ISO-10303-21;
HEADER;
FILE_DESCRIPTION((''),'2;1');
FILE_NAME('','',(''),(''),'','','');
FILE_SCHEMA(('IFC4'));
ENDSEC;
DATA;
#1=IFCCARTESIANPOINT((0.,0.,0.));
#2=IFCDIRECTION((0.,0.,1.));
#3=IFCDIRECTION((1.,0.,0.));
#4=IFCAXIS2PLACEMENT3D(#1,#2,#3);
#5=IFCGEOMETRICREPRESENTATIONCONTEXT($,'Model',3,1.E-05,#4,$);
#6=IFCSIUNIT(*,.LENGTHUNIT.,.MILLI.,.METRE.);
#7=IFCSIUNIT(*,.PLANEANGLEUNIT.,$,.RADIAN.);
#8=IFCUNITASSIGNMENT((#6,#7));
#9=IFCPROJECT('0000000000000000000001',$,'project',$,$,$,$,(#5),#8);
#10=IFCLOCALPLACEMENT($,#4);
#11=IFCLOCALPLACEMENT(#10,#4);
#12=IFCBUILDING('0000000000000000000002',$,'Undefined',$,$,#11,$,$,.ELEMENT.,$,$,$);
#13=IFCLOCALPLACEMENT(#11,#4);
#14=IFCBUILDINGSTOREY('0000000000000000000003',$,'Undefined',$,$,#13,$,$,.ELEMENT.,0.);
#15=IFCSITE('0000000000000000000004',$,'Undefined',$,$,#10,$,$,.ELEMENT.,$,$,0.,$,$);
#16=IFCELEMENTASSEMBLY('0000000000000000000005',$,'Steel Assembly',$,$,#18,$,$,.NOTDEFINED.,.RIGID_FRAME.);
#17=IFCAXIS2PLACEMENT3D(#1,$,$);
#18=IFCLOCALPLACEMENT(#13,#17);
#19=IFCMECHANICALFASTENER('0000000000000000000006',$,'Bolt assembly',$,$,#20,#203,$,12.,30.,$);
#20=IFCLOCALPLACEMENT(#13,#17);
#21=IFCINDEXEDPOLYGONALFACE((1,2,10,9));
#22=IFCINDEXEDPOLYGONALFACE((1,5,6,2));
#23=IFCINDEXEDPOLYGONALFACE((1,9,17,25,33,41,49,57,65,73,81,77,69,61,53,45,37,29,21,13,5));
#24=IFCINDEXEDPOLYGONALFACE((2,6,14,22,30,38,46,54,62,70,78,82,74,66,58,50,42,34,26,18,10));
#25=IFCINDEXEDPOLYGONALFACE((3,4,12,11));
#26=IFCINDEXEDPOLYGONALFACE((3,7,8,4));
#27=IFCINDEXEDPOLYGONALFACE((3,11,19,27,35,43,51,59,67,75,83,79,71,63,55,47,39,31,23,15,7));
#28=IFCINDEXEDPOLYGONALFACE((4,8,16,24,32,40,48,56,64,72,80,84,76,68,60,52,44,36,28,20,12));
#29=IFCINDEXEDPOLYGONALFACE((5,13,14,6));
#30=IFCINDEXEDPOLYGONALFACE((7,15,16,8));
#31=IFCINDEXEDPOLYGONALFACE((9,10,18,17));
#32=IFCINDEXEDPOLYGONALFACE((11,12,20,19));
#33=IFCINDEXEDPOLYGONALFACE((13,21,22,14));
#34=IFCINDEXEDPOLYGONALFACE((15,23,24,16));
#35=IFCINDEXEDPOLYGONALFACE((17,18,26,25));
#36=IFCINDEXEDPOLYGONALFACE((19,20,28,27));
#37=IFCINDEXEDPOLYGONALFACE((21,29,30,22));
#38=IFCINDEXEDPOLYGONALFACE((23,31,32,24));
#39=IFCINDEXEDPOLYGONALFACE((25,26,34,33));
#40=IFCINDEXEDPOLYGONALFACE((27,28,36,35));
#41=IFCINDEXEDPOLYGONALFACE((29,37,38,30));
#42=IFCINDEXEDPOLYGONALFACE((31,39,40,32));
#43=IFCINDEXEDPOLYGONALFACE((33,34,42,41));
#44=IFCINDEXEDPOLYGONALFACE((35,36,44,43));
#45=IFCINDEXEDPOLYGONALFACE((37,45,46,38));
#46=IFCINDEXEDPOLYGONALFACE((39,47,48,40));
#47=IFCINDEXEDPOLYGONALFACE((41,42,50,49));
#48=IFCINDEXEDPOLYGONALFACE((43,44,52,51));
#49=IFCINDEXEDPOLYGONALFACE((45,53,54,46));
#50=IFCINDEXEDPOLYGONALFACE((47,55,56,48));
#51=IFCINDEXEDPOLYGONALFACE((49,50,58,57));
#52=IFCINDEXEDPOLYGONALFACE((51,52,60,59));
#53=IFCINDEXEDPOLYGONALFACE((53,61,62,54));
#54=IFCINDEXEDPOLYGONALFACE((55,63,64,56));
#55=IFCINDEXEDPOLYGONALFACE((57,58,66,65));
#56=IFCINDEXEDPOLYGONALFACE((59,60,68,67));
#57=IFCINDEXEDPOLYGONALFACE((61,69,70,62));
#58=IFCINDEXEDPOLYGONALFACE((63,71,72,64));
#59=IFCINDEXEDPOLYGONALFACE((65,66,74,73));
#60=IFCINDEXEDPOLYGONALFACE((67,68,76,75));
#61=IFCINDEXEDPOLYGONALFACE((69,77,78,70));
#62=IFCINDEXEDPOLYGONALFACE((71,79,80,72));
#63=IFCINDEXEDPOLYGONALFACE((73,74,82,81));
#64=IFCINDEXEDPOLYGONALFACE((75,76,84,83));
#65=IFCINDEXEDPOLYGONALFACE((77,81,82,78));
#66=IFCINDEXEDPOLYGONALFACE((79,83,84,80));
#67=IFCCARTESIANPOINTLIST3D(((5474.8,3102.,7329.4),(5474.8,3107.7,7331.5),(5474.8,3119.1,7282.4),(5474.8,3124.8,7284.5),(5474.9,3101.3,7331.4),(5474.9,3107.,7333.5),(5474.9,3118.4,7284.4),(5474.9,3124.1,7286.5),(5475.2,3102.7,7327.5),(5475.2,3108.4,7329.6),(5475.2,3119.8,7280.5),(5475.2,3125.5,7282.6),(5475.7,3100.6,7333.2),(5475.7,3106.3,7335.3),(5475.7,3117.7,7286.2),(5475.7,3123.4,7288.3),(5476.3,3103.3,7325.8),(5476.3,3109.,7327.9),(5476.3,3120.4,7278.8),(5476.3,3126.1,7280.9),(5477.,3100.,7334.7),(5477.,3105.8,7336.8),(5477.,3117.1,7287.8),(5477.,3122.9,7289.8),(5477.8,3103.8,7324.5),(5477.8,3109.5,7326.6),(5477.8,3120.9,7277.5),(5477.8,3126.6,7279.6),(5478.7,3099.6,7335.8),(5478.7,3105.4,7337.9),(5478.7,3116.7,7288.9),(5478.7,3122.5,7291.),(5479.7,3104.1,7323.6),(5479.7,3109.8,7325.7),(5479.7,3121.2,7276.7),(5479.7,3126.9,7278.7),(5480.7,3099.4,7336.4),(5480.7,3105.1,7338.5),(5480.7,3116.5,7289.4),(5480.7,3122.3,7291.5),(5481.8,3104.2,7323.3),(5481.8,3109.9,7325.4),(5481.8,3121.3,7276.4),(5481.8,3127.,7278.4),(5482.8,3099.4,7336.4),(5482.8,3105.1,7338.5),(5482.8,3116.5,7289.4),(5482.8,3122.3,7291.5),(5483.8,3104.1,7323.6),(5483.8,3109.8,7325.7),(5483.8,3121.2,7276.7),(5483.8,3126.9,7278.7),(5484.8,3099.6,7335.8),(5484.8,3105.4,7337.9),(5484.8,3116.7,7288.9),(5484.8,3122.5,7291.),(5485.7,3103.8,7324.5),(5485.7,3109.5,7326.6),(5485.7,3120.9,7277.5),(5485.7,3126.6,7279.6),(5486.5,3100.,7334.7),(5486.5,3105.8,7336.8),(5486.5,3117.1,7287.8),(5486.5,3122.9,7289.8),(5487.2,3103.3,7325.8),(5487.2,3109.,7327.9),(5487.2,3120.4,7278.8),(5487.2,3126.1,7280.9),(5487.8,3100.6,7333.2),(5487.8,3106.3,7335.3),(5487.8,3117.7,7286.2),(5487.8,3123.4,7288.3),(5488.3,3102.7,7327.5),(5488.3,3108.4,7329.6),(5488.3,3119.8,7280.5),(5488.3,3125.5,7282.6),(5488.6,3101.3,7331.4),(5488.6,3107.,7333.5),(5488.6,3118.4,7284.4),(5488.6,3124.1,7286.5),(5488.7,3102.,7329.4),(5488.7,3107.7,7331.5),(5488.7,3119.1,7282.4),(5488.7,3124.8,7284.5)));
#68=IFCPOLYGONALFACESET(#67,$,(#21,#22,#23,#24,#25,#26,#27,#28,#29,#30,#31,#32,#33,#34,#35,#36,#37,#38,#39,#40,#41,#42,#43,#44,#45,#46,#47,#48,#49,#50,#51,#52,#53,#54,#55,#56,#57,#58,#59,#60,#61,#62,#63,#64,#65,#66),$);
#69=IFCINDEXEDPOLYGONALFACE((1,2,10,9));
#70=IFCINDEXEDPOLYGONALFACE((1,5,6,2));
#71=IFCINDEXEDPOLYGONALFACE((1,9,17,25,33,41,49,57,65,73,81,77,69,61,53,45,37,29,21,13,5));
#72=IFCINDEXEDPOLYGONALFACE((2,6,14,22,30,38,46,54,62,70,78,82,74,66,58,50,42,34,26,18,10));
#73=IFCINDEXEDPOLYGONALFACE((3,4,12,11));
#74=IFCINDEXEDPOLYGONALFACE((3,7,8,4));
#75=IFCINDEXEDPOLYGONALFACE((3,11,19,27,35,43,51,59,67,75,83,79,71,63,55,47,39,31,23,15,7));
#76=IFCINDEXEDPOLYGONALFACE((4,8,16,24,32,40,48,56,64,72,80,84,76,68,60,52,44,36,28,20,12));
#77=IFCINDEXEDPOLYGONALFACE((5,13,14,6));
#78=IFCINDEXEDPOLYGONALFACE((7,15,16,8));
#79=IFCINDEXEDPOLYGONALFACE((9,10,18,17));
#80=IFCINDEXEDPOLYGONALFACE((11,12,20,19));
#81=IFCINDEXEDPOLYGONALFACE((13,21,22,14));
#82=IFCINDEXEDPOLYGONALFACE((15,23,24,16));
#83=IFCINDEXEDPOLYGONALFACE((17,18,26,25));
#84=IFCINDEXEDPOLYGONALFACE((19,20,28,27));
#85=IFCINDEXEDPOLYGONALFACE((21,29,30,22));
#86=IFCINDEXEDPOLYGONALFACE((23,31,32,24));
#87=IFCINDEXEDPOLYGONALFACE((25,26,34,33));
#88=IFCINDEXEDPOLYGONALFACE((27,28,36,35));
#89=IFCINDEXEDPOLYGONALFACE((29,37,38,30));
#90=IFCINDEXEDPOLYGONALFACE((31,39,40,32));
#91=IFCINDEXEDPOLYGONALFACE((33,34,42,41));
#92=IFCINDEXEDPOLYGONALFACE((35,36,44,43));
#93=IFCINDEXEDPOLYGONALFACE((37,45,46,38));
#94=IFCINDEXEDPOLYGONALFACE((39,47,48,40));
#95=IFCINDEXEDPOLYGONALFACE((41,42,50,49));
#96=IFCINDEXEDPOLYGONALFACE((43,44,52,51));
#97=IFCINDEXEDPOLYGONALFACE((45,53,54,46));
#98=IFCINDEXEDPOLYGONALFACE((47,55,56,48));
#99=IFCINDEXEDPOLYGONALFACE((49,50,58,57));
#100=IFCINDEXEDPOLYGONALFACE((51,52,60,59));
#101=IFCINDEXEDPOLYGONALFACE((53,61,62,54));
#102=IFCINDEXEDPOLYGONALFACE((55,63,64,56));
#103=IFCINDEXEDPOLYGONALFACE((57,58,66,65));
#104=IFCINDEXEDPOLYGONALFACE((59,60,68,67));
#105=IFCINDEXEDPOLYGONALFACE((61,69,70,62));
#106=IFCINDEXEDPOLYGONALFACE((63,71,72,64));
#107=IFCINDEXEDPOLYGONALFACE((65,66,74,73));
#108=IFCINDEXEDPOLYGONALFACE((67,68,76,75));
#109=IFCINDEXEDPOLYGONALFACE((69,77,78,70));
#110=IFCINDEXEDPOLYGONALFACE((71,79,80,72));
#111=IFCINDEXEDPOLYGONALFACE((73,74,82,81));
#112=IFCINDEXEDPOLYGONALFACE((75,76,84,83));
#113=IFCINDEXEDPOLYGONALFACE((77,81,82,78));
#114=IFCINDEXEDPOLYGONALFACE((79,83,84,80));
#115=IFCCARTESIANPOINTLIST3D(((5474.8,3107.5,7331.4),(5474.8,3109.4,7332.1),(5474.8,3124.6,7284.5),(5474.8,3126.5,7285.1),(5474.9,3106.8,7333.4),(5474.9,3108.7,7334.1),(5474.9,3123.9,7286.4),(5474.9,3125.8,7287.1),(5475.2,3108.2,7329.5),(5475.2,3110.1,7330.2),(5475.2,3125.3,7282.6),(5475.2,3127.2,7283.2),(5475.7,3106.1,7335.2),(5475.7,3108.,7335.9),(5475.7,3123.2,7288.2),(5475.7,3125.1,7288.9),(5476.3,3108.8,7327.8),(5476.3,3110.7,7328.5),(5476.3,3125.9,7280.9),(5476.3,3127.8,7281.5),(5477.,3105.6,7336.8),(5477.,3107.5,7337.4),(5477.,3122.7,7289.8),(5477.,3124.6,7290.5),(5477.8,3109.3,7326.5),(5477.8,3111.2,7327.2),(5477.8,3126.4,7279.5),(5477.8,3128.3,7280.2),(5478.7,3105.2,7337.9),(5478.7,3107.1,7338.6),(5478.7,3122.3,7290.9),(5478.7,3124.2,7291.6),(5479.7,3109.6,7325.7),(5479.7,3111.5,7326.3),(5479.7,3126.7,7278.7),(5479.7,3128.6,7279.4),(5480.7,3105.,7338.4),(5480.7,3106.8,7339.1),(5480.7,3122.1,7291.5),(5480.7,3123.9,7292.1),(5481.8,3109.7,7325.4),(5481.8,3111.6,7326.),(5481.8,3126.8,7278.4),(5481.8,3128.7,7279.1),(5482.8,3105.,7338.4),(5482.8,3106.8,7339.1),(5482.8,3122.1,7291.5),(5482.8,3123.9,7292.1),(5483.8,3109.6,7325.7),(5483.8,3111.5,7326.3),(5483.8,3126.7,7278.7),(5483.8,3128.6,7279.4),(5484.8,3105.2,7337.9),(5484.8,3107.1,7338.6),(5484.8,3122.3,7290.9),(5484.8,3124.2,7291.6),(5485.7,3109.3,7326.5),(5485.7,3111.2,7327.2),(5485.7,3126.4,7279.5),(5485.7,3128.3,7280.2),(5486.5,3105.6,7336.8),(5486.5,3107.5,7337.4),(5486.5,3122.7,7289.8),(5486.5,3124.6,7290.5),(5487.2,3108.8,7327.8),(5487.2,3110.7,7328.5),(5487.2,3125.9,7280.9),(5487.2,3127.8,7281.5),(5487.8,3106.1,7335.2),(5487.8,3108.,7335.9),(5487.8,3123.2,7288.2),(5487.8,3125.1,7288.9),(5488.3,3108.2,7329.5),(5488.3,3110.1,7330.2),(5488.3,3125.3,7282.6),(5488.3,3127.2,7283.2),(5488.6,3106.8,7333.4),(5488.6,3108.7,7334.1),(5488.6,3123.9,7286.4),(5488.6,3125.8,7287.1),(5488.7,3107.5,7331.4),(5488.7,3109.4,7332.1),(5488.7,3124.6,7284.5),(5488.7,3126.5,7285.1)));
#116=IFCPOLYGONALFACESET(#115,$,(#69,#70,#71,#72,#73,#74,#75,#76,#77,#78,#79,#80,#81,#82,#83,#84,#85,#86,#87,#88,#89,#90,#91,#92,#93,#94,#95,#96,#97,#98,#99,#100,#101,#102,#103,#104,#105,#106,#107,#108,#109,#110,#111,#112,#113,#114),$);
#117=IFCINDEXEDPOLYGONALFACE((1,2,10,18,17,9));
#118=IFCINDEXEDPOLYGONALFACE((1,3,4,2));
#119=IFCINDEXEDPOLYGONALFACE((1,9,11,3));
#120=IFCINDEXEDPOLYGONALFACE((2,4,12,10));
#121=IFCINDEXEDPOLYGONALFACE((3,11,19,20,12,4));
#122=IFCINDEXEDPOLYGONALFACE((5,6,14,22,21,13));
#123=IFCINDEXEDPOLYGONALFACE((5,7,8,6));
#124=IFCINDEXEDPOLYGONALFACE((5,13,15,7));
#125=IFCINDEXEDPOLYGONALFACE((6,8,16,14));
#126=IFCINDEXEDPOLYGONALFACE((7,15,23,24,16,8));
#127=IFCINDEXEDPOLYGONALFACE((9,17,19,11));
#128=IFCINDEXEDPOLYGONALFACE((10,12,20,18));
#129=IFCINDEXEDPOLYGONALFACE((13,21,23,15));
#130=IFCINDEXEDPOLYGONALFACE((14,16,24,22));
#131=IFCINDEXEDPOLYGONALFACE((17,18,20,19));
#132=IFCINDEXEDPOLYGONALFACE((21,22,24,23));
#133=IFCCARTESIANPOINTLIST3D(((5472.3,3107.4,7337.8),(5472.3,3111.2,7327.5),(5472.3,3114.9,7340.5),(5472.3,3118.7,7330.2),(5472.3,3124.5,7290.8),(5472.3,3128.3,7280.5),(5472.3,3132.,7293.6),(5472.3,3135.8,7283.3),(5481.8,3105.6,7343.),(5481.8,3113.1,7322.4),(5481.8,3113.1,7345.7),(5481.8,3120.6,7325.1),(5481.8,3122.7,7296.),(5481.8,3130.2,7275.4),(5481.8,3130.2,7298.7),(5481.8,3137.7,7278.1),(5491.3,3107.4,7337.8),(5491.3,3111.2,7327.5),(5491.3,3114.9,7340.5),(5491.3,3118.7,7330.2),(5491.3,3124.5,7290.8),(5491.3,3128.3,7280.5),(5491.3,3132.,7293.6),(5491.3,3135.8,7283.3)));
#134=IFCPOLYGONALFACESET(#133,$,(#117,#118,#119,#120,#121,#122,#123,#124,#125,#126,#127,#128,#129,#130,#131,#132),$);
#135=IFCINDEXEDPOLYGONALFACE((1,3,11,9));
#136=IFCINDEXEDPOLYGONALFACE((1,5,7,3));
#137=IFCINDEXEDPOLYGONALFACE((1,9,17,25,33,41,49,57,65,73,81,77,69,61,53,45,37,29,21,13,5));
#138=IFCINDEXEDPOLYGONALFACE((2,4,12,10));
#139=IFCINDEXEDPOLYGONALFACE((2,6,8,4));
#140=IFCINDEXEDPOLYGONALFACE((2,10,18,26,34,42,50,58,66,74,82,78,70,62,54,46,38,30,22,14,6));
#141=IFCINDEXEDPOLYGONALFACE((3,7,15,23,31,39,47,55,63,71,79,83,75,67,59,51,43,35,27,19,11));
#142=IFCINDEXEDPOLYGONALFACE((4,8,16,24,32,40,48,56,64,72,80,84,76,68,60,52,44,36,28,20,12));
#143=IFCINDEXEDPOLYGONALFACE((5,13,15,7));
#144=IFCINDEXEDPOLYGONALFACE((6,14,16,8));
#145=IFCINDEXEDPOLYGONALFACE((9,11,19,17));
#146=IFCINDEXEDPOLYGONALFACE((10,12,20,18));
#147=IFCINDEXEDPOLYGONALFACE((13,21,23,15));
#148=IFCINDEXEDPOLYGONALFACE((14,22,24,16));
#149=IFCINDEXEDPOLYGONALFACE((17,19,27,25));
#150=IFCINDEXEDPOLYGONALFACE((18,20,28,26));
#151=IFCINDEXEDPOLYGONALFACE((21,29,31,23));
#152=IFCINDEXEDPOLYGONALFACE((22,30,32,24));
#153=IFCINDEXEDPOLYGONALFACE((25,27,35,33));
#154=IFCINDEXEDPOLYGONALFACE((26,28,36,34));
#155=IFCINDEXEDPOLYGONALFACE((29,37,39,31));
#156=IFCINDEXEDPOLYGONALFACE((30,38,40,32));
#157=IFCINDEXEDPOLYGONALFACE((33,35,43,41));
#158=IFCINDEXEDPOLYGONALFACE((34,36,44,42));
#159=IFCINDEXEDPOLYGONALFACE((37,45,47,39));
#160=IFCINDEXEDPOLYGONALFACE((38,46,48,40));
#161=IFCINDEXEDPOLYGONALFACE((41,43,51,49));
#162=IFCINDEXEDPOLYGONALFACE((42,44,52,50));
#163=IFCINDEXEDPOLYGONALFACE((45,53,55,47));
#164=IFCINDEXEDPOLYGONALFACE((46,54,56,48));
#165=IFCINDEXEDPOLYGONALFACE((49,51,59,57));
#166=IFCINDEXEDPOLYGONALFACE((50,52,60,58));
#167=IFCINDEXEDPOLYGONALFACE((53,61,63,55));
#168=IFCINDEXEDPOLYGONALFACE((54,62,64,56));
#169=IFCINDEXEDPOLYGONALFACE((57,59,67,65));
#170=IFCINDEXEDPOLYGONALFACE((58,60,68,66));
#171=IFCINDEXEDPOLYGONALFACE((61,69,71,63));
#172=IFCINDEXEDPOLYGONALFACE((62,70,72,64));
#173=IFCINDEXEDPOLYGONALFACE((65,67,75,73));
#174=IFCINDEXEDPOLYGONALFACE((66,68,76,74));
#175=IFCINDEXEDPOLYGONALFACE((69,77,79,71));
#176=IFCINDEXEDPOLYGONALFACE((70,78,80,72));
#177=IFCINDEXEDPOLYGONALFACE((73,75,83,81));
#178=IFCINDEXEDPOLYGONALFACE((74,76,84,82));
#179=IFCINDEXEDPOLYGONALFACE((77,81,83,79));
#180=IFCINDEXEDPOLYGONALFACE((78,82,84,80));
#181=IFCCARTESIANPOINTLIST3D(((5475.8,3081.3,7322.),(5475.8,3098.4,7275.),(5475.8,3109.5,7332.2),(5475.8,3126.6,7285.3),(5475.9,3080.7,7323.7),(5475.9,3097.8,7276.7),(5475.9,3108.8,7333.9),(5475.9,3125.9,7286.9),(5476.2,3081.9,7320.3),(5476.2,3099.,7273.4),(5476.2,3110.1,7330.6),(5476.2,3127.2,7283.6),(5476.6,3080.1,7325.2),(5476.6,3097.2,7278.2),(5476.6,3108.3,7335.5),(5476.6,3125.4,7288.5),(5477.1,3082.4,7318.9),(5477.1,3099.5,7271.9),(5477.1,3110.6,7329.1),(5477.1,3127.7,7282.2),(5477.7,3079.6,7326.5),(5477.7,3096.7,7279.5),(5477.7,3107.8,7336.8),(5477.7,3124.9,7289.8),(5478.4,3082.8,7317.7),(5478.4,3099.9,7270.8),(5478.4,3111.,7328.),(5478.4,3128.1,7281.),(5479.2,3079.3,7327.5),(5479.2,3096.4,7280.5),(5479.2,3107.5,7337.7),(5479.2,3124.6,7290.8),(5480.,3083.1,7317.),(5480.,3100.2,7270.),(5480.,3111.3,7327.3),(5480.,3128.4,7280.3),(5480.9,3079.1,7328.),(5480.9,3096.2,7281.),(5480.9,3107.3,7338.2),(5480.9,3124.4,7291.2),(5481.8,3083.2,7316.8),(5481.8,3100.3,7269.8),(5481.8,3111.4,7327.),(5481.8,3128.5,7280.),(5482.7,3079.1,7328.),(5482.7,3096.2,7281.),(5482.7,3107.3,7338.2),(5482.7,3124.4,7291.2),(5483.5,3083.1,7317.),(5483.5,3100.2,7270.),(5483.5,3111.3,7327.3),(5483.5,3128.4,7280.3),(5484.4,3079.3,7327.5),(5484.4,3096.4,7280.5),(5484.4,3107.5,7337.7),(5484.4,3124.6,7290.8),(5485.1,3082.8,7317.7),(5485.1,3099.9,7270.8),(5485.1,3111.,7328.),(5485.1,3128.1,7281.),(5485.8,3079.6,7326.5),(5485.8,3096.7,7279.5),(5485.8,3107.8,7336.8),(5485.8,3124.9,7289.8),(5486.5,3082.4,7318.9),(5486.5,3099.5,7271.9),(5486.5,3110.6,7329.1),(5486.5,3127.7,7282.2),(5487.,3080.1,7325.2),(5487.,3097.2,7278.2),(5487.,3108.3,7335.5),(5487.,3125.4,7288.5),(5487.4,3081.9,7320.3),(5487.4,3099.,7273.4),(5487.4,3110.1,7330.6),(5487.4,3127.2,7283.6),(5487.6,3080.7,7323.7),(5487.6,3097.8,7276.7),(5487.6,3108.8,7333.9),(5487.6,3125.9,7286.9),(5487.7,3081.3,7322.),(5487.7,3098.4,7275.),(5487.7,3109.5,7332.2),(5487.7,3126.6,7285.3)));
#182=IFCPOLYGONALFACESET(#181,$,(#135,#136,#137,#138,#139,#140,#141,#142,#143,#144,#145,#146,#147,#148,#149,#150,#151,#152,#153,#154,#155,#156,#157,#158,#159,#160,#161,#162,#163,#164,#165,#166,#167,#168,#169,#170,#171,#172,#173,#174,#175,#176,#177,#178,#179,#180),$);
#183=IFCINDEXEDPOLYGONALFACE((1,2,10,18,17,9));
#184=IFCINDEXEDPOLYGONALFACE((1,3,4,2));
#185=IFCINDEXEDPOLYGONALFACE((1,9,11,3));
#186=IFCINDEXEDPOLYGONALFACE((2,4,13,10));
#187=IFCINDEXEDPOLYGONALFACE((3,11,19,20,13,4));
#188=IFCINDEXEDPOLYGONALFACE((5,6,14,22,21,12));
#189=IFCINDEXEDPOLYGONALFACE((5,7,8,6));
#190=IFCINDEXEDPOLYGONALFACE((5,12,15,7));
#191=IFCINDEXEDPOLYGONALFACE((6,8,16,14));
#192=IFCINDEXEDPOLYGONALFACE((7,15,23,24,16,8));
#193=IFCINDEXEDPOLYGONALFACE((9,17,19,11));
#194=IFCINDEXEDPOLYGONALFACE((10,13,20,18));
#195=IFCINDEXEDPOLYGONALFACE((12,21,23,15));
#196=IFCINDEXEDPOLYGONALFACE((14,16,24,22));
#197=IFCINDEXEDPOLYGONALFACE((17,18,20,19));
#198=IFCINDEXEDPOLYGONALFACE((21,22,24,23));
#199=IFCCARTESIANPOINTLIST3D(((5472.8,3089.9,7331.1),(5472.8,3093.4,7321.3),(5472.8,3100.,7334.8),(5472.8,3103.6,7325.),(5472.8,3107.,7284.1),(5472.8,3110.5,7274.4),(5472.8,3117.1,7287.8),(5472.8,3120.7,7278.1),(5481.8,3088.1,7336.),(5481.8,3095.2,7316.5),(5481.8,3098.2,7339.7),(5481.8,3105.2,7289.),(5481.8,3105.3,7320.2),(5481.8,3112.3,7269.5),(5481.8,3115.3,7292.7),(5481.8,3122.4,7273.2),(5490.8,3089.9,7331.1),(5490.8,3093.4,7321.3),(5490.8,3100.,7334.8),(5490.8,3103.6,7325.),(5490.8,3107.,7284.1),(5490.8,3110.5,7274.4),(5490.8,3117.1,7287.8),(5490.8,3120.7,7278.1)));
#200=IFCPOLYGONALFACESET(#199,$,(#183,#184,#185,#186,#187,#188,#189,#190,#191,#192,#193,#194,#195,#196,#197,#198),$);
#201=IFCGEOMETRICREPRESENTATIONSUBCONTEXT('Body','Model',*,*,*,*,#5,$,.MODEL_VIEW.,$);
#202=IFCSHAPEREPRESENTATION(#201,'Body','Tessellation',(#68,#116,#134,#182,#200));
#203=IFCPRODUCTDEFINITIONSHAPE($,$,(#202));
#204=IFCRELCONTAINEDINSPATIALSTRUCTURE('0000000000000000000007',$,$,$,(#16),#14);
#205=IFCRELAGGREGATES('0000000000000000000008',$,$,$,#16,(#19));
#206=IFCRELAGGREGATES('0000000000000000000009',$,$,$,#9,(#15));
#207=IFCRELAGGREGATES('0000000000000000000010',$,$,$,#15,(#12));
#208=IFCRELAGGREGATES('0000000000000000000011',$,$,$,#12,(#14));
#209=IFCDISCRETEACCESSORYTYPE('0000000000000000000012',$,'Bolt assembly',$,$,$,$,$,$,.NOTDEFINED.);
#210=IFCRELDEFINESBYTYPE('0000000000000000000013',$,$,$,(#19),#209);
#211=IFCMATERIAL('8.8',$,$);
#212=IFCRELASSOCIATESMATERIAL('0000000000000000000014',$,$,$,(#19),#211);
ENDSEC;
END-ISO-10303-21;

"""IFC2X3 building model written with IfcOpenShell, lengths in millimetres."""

from ifc_helpers import new_model, si_unit, frame, origin_with_axes, origin_2d_with_axis, place, context, subcontext, project, spatial, polyline, circle, outline, extrude, source, transform, mapped, material, type_object, element, aggregate, save


model = new_model("IFC2X3")

# Units and contexts
model_context = context("Model", 3, precision=1e-05, world=origin_with_axes())
body_context = subcontext(model_context, "Body", "Model", "MODEL_VIEW")
ifc_project = project(units=[si_unit("LENGTHUNIT", "METRE", prefix="MILLI"), si_unit("PLANEANGLEUNIT", "RADIAN")], contexts=[model_context])

# Site, building, storey
site_placement = place(None, origin_with_axes())
site = spatial("IfcSite", under=ifc_project, at=site_placement, Name="Undefined", CompositionType="ELEMENT", RefElevation=0.0)
building_placement = place(site_placement, origin_with_axes())
building = spatial("IfcBuilding", under=site, at=building_placement, Name="Undefined", CompositionType="ELEMENT")
storey_placement = place(building_placement, origin_with_axes())
storey = spatial("IfcBuildingStorey", under=building, at=storey_placement, Name="Undefined", CompositionType="ELEMENT", Elevation=0.0)

# Shared definitions
ifc_material_1 = material(Name="8.8")
discrete_accessory_type_1 = type_object("IfcDiscreteAccessoryType", Name="Bolt assembly")
shared_shape_1 = source(origin_with_axes(), body_context, "Body", "SweptSolid", [
    extrude(circle(Radius=7.0, at=origin_2d_with_axis()), frame((0.0, -6.1, 0.0), z_axis=(0.0, 1.0, 0.0), x_axis=(1.0, 0.0, 0.0)), (0.0, 0.0, 1.0), 6.1),
    extrude(circle(Radius=7.0, at=origin_2d_with_axis()), frame((0.0, -7.9, 0.0), z_axis=(0.0, 1.0, 0.0), x_axis=(1.0, 0.0, 0.0)), (0.0, 0.0, 1.0), 2.0),
    extrude(outline(polyline([(11.0, 0.0), (5.5, 9.5), (-5.5, 9.5), (-11.0, 0.0), (-5.5, -9.5), (5.5, -9.5), (11.0, 0.0)])), frame((0.0, -16.0, 0.0), z_axis=(0.0, 1.0, 0.0), x_axis=(1.0, 0.0, 0.0)), (0.0, 0.0, 1.0), 8.0),
    extrude(circle(Radius=6.0, at=origin_2d_with_axis()), frame((0.0, -8.0, 0.0), z_axis=(0.0, 1.0, 0.0), x_axis=(1.0, 0.0, 0.0)), (0.0, 0.0, 1.0), 30.0),
    extrude(outline(polyline([(10.4, 0.0), (5.2, 9.0), (-5.2, 9.0), (-10.4, 0.0), (-5.2, -9.0), (5.2, -9.0), (10.4, 0.0)])), frame((0.0, 0.0, 0.0), z_axis=(0.0, 1.0, 0.0), x_axis=(1.0, 0.0, 0.0)), (0.0, 0.0, 1.0), 10.8),
])

# Element assembly, mechanical fastener
assembly_1_placement = place(storey_placement, origin_with_axes())
assembly_1 = element("IfcElementAssembly", 1, at=assembly_1_placement, inside=storey, Name="Steel Assembly", AssemblyPlace="NOTDEFINED", PredefinedType="RIGID_FRAME")
mechanical_fastener_1_placement = place(assembly_1_placement, frame((5481.8, 3101.8, 7329.9), z_axis=(-1.0, 0.0, 0.0), x_axis=(0.0, 0.34202, -0.939693)))
mechanical_fastener_1 = element("IfcMechanicalFastener", 2, at=mechanical_fastener_1_placement, type_object=discrete_accessory_type_1, material=ifc_material_1, Name="Bolt assembly", NominalDiameter=12.0, NominalLength=30.0, context=body_context, shape_type="MappedRepresentation", body=[
    mapped(shared_shape_1, transform((0.0, 0.0, 0.0))),
    mapped(shared_shape_1, transform((50.0, 0.0, 0.0))),
])
aggregate(assembly_1, [mechanical_fastener_1])

save(model, "model.ifc")
